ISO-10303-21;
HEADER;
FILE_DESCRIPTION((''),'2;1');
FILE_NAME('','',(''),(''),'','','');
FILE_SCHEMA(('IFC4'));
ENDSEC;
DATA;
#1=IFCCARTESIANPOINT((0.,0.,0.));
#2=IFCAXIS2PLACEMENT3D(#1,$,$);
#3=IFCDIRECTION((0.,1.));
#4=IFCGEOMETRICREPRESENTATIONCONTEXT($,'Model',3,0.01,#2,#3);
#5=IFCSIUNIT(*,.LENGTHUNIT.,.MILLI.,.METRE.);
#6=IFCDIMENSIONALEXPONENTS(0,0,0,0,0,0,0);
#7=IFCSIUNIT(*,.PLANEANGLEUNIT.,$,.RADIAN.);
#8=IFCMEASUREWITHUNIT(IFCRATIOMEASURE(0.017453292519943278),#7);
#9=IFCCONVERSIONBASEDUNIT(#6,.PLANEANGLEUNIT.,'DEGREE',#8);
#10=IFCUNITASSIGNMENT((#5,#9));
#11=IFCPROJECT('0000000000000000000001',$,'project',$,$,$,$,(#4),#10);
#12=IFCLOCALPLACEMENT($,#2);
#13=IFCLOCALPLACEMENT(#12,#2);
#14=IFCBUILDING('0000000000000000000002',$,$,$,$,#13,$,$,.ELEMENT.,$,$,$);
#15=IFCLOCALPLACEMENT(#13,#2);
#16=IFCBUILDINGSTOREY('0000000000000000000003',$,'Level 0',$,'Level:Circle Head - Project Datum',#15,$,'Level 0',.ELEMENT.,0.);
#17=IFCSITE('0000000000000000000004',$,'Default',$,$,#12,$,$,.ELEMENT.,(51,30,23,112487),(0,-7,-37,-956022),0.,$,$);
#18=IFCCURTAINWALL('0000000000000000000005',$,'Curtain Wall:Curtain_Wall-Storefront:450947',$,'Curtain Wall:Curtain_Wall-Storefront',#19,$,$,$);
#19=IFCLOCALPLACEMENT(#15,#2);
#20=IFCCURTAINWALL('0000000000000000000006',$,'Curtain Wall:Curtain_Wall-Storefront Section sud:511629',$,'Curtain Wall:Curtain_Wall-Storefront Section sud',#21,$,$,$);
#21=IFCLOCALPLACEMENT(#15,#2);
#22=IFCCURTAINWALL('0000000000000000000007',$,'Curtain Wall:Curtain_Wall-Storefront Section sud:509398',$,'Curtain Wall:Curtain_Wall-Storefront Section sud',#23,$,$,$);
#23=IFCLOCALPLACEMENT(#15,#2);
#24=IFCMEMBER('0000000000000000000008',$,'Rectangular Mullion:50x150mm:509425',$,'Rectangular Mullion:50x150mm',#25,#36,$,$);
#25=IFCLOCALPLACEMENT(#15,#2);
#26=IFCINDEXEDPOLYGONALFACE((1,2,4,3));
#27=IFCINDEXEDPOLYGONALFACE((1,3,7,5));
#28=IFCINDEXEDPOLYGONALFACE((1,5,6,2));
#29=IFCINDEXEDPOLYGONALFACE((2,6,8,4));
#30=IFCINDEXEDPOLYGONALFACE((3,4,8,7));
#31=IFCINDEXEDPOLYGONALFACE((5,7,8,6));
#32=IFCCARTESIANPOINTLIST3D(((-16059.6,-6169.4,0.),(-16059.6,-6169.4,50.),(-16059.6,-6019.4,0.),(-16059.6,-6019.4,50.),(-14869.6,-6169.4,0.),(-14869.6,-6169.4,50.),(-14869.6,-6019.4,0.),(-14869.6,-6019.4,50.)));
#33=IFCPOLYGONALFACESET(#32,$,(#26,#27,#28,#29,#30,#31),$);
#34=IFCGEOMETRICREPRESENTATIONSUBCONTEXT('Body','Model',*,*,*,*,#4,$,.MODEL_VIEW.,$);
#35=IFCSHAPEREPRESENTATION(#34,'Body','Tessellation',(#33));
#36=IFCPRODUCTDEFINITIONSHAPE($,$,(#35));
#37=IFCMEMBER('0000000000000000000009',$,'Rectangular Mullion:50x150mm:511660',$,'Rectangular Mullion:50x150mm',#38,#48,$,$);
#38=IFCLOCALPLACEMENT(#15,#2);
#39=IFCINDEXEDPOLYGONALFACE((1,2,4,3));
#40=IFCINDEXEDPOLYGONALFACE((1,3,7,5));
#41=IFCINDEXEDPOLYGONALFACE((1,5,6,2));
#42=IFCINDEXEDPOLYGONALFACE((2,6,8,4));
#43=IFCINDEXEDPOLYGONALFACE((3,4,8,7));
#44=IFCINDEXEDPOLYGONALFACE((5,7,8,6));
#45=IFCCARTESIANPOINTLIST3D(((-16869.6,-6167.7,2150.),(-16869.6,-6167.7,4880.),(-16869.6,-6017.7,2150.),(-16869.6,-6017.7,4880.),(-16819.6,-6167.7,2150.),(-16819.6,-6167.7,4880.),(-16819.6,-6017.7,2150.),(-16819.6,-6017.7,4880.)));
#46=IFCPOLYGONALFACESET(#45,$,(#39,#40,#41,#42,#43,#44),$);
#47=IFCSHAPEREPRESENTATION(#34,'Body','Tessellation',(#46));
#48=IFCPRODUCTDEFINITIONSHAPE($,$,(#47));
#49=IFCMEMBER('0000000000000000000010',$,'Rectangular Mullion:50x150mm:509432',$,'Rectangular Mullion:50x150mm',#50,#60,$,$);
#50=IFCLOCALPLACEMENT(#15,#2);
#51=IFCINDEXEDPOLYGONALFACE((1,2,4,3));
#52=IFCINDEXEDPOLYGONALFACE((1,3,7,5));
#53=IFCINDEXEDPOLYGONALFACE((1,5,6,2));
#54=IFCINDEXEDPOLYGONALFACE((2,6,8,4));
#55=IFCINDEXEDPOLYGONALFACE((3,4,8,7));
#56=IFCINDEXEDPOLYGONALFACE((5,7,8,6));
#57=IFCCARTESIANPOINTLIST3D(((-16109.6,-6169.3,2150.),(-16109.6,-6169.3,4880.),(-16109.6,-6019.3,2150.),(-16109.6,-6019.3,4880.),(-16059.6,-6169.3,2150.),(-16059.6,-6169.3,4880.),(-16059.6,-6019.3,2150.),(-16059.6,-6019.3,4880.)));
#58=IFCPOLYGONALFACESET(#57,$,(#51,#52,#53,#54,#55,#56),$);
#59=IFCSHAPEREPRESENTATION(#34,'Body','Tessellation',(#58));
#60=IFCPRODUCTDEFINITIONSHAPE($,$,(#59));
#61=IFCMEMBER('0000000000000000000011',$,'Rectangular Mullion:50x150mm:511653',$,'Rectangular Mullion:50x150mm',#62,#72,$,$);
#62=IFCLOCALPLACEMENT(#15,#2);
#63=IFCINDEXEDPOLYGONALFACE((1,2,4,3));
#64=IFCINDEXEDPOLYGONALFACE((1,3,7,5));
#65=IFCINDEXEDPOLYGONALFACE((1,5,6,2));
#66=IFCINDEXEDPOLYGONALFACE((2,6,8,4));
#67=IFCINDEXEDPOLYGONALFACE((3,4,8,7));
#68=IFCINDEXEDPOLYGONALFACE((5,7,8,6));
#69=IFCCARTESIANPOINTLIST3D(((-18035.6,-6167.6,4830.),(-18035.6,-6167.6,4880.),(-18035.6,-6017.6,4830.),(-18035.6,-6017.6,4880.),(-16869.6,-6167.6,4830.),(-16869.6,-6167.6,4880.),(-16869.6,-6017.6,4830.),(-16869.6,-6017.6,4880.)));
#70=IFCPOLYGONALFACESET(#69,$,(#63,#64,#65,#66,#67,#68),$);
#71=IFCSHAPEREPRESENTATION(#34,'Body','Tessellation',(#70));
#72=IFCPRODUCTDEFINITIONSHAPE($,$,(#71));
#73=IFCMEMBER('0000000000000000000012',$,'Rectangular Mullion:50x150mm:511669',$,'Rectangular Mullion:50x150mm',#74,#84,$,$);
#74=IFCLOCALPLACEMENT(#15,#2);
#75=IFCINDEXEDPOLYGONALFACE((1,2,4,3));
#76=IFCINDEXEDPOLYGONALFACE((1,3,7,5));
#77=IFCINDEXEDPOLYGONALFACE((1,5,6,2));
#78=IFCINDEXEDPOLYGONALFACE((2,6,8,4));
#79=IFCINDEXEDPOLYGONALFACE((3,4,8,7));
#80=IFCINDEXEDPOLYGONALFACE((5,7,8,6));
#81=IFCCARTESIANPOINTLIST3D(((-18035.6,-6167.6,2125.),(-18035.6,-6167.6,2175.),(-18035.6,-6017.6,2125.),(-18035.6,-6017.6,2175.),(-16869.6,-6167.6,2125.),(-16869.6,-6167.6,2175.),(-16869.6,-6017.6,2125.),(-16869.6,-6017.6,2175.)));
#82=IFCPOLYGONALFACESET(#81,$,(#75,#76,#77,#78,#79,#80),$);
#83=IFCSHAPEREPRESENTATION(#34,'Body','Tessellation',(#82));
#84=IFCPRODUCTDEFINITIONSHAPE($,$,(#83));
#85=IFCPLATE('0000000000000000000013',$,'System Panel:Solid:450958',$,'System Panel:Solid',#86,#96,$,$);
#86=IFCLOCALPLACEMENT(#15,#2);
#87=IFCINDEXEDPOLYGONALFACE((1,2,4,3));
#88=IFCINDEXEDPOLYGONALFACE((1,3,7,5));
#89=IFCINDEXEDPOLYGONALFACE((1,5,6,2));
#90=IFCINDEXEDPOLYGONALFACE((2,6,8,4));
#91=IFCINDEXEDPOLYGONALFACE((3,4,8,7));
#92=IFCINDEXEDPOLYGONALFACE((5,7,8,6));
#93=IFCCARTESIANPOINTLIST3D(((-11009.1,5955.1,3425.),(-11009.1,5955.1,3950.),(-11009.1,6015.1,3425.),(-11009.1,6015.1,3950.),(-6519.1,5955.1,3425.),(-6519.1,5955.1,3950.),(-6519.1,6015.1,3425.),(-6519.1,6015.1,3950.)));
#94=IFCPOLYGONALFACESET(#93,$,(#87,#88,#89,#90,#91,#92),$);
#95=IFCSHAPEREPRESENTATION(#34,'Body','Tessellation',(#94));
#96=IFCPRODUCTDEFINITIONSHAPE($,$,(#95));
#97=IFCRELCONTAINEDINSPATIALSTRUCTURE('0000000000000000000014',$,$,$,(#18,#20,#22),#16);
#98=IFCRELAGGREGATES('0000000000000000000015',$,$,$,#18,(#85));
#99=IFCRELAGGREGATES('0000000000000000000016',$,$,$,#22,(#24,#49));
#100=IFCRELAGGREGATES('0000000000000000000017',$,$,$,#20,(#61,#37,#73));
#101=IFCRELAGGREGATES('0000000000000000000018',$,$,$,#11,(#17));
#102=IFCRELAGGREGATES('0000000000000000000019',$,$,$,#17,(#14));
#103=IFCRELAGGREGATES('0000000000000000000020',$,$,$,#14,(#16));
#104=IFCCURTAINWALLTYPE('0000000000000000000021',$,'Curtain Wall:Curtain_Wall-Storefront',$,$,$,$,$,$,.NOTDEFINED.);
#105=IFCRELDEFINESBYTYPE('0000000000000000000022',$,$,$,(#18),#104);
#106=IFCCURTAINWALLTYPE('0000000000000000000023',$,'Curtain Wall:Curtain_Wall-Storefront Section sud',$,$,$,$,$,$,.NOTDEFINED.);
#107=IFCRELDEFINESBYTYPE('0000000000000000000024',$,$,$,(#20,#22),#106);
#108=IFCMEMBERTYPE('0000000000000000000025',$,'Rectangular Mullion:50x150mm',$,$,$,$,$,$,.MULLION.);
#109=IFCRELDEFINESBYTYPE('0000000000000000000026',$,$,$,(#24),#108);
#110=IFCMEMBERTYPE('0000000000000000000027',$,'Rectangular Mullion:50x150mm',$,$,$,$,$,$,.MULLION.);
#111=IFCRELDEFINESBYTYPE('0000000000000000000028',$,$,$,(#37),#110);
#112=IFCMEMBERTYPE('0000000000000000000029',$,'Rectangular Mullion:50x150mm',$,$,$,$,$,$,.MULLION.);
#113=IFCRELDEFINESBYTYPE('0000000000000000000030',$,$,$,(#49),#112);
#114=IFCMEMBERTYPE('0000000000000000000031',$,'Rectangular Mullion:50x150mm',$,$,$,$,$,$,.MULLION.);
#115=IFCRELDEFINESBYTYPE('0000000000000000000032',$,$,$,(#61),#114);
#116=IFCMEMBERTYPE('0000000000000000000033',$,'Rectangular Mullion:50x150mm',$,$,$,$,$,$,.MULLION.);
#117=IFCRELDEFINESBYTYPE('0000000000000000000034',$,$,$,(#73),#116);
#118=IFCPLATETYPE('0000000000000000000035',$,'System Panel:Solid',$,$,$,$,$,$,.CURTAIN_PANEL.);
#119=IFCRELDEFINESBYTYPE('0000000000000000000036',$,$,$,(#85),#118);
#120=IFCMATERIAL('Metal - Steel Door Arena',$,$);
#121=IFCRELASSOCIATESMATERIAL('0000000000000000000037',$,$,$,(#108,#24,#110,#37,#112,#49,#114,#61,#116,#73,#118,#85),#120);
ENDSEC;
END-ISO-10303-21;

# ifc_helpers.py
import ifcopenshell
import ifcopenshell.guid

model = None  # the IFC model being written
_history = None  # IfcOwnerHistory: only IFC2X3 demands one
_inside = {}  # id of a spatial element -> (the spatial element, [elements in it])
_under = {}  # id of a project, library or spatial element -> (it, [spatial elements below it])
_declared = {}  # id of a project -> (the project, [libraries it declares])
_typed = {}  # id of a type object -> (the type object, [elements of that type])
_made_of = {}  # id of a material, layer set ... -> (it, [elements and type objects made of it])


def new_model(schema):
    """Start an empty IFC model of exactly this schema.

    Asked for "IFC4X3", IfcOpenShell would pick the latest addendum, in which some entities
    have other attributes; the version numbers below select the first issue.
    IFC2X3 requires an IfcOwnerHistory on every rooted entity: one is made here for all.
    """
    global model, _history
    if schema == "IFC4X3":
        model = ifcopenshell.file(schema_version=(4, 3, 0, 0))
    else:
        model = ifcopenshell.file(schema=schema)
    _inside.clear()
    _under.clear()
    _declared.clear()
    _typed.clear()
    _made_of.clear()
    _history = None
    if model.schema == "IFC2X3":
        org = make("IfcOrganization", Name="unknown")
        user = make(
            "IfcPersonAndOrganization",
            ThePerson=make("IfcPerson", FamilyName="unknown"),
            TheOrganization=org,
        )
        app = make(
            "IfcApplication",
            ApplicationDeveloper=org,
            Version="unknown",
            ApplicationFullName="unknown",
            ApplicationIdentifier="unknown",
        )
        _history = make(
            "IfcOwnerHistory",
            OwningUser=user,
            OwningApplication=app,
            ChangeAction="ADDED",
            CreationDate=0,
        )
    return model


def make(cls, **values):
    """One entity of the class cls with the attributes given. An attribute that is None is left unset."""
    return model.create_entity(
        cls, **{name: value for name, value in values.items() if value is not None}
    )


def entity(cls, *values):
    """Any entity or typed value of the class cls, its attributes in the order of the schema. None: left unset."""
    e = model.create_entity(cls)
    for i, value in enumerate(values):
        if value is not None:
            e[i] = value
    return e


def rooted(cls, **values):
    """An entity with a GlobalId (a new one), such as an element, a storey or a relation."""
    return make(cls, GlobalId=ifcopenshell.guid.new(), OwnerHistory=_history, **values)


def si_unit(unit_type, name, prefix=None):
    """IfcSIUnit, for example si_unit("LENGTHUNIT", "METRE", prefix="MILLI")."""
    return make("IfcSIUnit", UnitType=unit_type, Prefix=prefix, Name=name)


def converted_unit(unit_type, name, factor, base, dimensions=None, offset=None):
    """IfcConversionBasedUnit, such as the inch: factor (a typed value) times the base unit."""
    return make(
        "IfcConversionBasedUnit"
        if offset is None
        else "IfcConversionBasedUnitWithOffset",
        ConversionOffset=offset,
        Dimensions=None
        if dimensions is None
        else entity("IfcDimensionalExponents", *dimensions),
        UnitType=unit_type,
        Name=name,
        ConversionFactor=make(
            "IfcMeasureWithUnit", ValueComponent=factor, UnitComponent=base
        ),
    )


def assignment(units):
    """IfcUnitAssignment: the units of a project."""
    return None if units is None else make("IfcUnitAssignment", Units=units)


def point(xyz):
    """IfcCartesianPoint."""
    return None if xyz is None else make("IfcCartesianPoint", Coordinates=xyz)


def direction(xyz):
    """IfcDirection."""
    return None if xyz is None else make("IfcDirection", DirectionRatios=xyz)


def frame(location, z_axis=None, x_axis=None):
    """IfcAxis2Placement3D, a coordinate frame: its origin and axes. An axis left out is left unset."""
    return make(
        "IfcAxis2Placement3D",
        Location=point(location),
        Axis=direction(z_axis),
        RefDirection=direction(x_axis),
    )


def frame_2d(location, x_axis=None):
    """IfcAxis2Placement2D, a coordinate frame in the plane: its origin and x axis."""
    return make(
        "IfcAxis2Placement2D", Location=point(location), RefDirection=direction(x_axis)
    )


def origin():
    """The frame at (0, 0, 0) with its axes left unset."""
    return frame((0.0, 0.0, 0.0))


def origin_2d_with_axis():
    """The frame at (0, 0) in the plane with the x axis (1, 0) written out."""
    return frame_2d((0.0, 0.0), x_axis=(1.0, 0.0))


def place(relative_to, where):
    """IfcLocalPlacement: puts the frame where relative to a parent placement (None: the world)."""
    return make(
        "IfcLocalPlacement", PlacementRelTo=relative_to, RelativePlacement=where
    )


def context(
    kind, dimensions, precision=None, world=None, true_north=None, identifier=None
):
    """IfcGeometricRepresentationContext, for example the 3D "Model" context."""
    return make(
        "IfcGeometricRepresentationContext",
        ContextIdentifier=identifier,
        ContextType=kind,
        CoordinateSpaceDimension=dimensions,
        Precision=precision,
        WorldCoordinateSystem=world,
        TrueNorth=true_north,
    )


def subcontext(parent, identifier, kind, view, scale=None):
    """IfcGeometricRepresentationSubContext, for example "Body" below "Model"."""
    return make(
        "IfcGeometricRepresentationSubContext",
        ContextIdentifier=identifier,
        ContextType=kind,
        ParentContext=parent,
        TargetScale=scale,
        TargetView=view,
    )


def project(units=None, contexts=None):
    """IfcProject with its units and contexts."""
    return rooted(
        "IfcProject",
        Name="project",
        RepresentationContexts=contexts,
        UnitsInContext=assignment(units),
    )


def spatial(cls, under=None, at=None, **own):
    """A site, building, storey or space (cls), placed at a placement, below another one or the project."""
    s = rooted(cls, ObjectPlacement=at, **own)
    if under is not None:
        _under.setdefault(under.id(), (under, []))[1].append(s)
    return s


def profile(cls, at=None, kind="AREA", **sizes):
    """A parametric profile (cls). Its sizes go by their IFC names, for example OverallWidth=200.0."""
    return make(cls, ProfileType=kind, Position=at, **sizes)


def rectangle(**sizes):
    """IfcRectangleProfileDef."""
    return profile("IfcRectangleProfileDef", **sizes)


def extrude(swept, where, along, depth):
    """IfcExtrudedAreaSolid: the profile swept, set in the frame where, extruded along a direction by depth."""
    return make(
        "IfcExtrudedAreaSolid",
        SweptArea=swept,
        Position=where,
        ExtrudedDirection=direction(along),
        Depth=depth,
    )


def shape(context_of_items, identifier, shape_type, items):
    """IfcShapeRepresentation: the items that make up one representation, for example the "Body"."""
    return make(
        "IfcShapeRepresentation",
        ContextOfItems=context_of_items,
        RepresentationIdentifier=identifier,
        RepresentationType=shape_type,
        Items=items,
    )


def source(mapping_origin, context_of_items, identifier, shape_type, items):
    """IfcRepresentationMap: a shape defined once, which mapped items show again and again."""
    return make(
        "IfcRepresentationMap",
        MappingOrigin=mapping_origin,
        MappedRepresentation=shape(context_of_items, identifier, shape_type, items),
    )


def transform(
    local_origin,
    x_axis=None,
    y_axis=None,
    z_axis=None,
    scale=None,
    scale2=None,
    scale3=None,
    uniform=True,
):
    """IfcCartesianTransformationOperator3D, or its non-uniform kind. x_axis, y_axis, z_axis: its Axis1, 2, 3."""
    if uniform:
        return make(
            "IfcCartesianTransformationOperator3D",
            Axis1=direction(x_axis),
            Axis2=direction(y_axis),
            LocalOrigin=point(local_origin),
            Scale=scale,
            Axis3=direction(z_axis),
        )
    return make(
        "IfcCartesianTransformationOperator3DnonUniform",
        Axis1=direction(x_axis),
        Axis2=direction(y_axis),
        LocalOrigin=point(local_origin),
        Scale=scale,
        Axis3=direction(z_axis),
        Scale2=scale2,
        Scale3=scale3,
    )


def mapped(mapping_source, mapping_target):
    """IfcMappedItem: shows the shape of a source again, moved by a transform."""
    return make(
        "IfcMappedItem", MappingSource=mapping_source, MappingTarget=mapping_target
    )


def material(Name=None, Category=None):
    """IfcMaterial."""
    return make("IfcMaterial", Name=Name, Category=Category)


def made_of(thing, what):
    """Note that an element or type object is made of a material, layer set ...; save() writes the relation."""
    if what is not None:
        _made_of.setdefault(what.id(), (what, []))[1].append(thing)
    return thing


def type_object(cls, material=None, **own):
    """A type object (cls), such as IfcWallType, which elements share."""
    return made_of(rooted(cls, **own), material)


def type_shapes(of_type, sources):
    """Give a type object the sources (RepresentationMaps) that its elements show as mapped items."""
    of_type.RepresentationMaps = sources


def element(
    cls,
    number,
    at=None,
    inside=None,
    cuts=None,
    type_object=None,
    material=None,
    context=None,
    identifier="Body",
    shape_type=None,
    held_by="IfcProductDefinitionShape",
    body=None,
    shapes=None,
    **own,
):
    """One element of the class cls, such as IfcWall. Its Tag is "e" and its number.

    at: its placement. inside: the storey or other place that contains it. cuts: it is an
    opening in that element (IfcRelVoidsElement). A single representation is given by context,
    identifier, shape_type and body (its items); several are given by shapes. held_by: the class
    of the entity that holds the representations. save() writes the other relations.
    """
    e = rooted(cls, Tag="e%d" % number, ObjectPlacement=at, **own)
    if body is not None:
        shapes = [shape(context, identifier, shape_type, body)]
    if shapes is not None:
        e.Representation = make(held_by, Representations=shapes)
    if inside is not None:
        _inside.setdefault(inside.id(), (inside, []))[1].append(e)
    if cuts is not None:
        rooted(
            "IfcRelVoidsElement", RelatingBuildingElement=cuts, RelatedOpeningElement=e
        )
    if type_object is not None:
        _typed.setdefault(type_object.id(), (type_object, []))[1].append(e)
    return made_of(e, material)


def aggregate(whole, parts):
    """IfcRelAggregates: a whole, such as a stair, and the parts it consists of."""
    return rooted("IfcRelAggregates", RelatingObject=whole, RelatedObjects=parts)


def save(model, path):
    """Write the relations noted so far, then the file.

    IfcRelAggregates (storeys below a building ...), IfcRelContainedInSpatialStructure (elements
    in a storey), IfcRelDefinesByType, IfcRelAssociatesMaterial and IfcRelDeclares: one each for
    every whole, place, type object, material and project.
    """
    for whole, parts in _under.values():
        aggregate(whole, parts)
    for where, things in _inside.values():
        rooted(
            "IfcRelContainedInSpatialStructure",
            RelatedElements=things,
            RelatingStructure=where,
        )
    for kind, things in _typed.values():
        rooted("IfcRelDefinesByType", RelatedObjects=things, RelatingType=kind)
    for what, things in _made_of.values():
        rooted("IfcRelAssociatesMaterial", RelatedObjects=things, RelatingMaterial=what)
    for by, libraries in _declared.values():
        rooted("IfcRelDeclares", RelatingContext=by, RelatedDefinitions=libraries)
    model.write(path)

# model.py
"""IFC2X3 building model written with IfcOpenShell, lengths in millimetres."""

from ifc_helpers import new_model, entity, si_unit, converted_unit, direction, frame, frame_2d, origin, origin_2d_with_axis, place, context, subcontext, project, spatial, rectangle, extrude, source, transform, mapped, material, type_object, type_shapes, element, aggregate, save


model = new_model("IFC2X3")

# Units and contexts
model_context = context("Model", 3, precision=0.01, world=origin(), true_north=direction((0.0, 1.0)))
body_context = subcontext(model_context, "Body", "Model", "MODEL_VIEW")
ifc_project = project(units=[si_unit("LENGTHUNIT", "METRE", prefix="MILLI"), converted_unit("PLANEANGLEUNIT", "DEGREE", entity("IfcRatioMeasure", 0.017453292519943278), si_unit("PLANEANGLEUNIT", "RADIAN"), dimensions=[0, 0, 0, 0, 0, 0, 0])], contexts=[model_context])

# Site, building, storey
site_placement = place(None, origin())
site = spatial("IfcSite", under=ifc_project, at=site_placement, Name="Default", CompositionType="ELEMENT", RefLatitude=(51, 30, 23, 112487), RefLongitude=(0, -7, -37, -956022), RefElevation=0.0)
building_placement = place(site_placement, origin())
building = spatial("IfcBuilding", under=site, at=building_placement, CompositionType="ELEMENT")
storey_placement = place(building_placement, origin())
storey = spatial("IfcBuildingStorey", under=building, at=storey_placement, Name="Level 0", ObjectType="Level:Circle Head - Project Datum", LongName="Level 0", CompositionType="ELEMENT", Elevation=0.0)

# Curtain walls
curtain_wall_type_1 = type_object("IfcCurtainWallType", Name="Curtain Wall:Curtain_Wall-Storefront", PredefinedType="NOTDEFINED")
curtain_wall_1_placement = place(storey_placement, origin())
curtain_wall_1 = element("IfcCurtainWall", 1, at=curtain_wall_1_placement, inside=storey, type_object=curtain_wall_type_1, Name="Curtain Wall:Curtain_Wall-Storefront:450947", ObjectType="Curtain Wall:Curtain_Wall-Storefront")
ifc_material_1 = material(Name="Metal - Steel Door Arena")
curtain_wall_type_2 = type_object("IfcCurtainWallType", Name="Curtain Wall:Curtain_Wall-Storefront Section sud", PredefinedType="NOTDEFINED")
curtain_wall_2_placement = place(storey_placement, origin())
curtain_wall_2 = element("IfcCurtainWall", 2, at=curtain_wall_2_placement, inside=storey, type_object=curtain_wall_type_2, Name="Curtain Wall:Curtain_Wall-Storefront Section sud:511629", ObjectType="Curtain Wall:Curtain_Wall-Storefront Section sud")
curtain_wall_3_placement = place(storey_placement, origin())
curtain_wall_3 = element("IfcCurtainWall", 3, at=curtain_wall_3_placement, inside=storey, type_object=curtain_wall_type_2, Name="Curtain Wall:Curtain_Wall-Storefront Section sud:509398", ObjectType="Curtain Wall:Curtain_Wall-Storefront Section sud")

# Members
member_type_1 = type_object("IfcMemberType", Name="Rectangular Mullion:50x150mm", PredefinedType="MULLION", material=ifc_material_1)
shared_shape_1 = source(origin(), body_context, "Body", "SweptSolid", [
    extrude(rectangle(XDim=150.0, YDim=50.0, at=origin_2d_with_axis()), frame((-25.0, 0.0, -1190.0), z_axis=(0.0, 0.0, 1.0), x_axis=(0.0, -1.0, 0.0)), (0.0, 0.0, 1.0), 1190.0),
])
type_shapes(member_type_1, [shared_shape_1])
member_1_placement = place(curtain_wall_3_placement, frame((-16059.6, -6094.4, 0.0), z_axis=(-1.0, 0.0, 0.0), x_axis=(0.0, 0.0, -1.0)))
member_1 = element("IfcMember", 4, at=member_1_placement, type_object=member_type_1, material=ifc_material_1, Name="Rectangular Mullion:50x150mm:509425", ObjectType="Rectangular Mullion:50x150mm", context=body_context, shape_type="MappedRepresentation", body=[
    mapped(shared_shape_1, transform((0.0, 0.0, 0.0), scale=1.0)),
])
member_type_2 = type_object("IfcMemberType", Name="Rectangular Mullion:50x150mm", PredefinedType="MULLION", material=ifc_material_1)
shared_shape_2 = source(origin(), body_context, "Body", "SweptSolid", [
    extrude(rectangle(XDim=150.0, YDim=50.0, at=origin_2d_with_axis()), frame((-25.0, 0.0, -2730.0), z_axis=(0.0, 0.0, 1.0), x_axis=(0.0, -1.0, 0.0)), (0.0, 0.0, 1.0), 2730.0),
])
type_shapes(member_type_2, [shared_shape_2])
member_2_placement = place(curtain_wall_2_placement, frame((-16819.6, -6092.7, 2150.0), z_axis=(0.0, 0.0, -1.0), x_axis=(1.0, 0.0, 0.0)))
member_2 = element("IfcMember", 5, at=member_2_placement, type_object=member_type_2, material=ifc_material_1, Name="Rectangular Mullion:50x150mm:511660", ObjectType="Rectangular Mullion:50x150mm", context=body_context, shape_type="MappedRepresentation", body=[
    mapped(shared_shape_2, transform((0.0, 0.0, 0.0), scale=1.0)),
])
member_type_3 = type_object("IfcMemberType", Name="Rectangular Mullion:50x150mm", PredefinedType="MULLION", material=ifc_material_1)
shared_shape_3 = source(origin(), body_context, "Body", "SweptSolid", [
    extrude(rectangle(XDim=150.0, YDim=50.0, at=origin_2d_with_axis()), frame((-25.0, 0.0, -2730.0), z_axis=(0.0, 0.0, 1.0), x_axis=(0.0, -1.0, 0.0)), (0.0, 0.0, 1.0), 2730.0),
])
type_shapes(member_type_3, [shared_shape_3])
member_3_placement = place(curtain_wall_3_placement, frame((-16109.6, -6094.3, 4880.0), z_axis=(0.0, 0.0, 1.0), x_axis=(-1.0, 0.0, 0.0)))
member_3 = element("IfcMember", 6, at=member_3_placement, type_object=member_type_3, material=ifc_material_1, Name="Rectangular Mullion:50x150mm:509432", ObjectType="Rectangular Mullion:50x150mm", context=body_context, shape_type="MappedRepresentation", body=[
    mapped(shared_shape_3, transform((0.0, 0.0, 0.0), scale=1.0)),
])
member_type_4 = type_object("IfcMemberType", Name="Rectangular Mullion:50x150mm", PredefinedType="MULLION", material=ifc_material_1)
shared_shape_4 = source(origin(), body_context, "Body", "SweptSolid", [
    extrude(rectangle(XDim=150.0, YDim=50.0, at=origin_2d_with_axis()), frame((-25.0, 0.0, -1166.0), z_axis=(0.0, 0.0, 1.0), x_axis=(0.0, -1.0, 0.0)), (0.0, 0.0, 1.0), 1166.0),
])
type_shapes(member_type_4, [shared_shape_4])
member_4_placement = place(curtain_wall_2_placement, frame((-16869.6, -6092.6, 4880.0), z_axis=(1.0, 0.0, 0.0), x_axis=(0.0, 0.0, 1.0)))
member_4 = element("IfcMember", 7, at=member_4_placement, type_object=member_type_4, material=ifc_material_1, Name="Rectangular Mullion:50x150mm:511653", ObjectType="Rectangular Mullion:50x150mm", context=body_context, shape_type="MappedRepresentation", body=[
    mapped(shared_shape_4, transform((0.0, 0.0, 0.0), scale=1.0)),
])
member_type_5 = type_object("IfcMemberType", Name="Rectangular Mullion:50x150mm", PredefinedType="MULLION", material=ifc_material_1)
shared_shape_5 = source(origin(), body_context, "Body", "SweptSolid", [
    extrude(rectangle(XDim=150.0, YDim=50.0, at=origin_2d_with_axis()), frame((0.0, 0.0, -1166.0), z_axis=(0.0, 0.0, 1.0), x_axis=(0.0, -1.0, 0.0)), (0.0, 0.0, 1.0), 1166.0),
])
type_shapes(member_type_5, [shared_shape_5])
member_5_placement = place(curtain_wall_2_placement, frame((-16869.6, -6092.6, 2150.0), z_axis=(1.0, 0.0, 0.0), x_axis=(0.0, 0.0, 1.0)))
member_5 = element("IfcMember", 8, at=member_5_placement, type_object=member_type_5, material=ifc_material_1, Name="Rectangular Mullion:50x150mm:511669", ObjectType="Rectangular Mullion:50x150mm", context=body_context, shape_type="MappedRepresentation", body=[
    mapped(shared_shape_5, transform((0.0, 0.0, 0.0), scale=1.0)),
])

# Plate
plate_type_1 = type_object("IfcPlateType", Name="System Panel:Solid", PredefinedType="CURTAIN_PANEL", material=ifc_material_1)
shared_shape_6 = source(origin(), body_context, "Body", "SweptSolid", [
    extrude(rectangle(XDim=525.0, YDim=4490.0, at=frame_2d((0.0, 0.0), x_axis=(1.0, 0.0))), frame((0.0, 15.0, 262.5), z_axis=(0.0, 1.0, 0.0), x_axis=(0.0, 0.0, 1.0)), (0.0, 0.0, 1.0), 60.0),
])
type_shapes(plate_type_1, [shared_shape_6])
plate_1_placement = place(curtain_wall_1_placement, frame((-8764.1, 6030.1, 3425.0), z_axis=(0.0, 0.0, 1.0), x_axis=(-1.0, 0.0, 0.0)))
plate_1 = element("IfcPlate", 9, at=plate_1_placement, type_object=plate_type_1, material=ifc_material_1, Name="System Panel:Solid:450958", ObjectType="System Panel:Solid", context=body_context, shape_type="MappedRepresentation", body=[
    mapped(shared_shape_6, transform((0.0, 0.0, 0.0), scale=1.0)),
])
aggregate(curtain_wall_1, [plate_1])
aggregate(curtain_wall_3, [member_1, member_3])
aggregate(curtain_wall_2, [member_4, member_2, member_5])

save(model, "model.ifc")
